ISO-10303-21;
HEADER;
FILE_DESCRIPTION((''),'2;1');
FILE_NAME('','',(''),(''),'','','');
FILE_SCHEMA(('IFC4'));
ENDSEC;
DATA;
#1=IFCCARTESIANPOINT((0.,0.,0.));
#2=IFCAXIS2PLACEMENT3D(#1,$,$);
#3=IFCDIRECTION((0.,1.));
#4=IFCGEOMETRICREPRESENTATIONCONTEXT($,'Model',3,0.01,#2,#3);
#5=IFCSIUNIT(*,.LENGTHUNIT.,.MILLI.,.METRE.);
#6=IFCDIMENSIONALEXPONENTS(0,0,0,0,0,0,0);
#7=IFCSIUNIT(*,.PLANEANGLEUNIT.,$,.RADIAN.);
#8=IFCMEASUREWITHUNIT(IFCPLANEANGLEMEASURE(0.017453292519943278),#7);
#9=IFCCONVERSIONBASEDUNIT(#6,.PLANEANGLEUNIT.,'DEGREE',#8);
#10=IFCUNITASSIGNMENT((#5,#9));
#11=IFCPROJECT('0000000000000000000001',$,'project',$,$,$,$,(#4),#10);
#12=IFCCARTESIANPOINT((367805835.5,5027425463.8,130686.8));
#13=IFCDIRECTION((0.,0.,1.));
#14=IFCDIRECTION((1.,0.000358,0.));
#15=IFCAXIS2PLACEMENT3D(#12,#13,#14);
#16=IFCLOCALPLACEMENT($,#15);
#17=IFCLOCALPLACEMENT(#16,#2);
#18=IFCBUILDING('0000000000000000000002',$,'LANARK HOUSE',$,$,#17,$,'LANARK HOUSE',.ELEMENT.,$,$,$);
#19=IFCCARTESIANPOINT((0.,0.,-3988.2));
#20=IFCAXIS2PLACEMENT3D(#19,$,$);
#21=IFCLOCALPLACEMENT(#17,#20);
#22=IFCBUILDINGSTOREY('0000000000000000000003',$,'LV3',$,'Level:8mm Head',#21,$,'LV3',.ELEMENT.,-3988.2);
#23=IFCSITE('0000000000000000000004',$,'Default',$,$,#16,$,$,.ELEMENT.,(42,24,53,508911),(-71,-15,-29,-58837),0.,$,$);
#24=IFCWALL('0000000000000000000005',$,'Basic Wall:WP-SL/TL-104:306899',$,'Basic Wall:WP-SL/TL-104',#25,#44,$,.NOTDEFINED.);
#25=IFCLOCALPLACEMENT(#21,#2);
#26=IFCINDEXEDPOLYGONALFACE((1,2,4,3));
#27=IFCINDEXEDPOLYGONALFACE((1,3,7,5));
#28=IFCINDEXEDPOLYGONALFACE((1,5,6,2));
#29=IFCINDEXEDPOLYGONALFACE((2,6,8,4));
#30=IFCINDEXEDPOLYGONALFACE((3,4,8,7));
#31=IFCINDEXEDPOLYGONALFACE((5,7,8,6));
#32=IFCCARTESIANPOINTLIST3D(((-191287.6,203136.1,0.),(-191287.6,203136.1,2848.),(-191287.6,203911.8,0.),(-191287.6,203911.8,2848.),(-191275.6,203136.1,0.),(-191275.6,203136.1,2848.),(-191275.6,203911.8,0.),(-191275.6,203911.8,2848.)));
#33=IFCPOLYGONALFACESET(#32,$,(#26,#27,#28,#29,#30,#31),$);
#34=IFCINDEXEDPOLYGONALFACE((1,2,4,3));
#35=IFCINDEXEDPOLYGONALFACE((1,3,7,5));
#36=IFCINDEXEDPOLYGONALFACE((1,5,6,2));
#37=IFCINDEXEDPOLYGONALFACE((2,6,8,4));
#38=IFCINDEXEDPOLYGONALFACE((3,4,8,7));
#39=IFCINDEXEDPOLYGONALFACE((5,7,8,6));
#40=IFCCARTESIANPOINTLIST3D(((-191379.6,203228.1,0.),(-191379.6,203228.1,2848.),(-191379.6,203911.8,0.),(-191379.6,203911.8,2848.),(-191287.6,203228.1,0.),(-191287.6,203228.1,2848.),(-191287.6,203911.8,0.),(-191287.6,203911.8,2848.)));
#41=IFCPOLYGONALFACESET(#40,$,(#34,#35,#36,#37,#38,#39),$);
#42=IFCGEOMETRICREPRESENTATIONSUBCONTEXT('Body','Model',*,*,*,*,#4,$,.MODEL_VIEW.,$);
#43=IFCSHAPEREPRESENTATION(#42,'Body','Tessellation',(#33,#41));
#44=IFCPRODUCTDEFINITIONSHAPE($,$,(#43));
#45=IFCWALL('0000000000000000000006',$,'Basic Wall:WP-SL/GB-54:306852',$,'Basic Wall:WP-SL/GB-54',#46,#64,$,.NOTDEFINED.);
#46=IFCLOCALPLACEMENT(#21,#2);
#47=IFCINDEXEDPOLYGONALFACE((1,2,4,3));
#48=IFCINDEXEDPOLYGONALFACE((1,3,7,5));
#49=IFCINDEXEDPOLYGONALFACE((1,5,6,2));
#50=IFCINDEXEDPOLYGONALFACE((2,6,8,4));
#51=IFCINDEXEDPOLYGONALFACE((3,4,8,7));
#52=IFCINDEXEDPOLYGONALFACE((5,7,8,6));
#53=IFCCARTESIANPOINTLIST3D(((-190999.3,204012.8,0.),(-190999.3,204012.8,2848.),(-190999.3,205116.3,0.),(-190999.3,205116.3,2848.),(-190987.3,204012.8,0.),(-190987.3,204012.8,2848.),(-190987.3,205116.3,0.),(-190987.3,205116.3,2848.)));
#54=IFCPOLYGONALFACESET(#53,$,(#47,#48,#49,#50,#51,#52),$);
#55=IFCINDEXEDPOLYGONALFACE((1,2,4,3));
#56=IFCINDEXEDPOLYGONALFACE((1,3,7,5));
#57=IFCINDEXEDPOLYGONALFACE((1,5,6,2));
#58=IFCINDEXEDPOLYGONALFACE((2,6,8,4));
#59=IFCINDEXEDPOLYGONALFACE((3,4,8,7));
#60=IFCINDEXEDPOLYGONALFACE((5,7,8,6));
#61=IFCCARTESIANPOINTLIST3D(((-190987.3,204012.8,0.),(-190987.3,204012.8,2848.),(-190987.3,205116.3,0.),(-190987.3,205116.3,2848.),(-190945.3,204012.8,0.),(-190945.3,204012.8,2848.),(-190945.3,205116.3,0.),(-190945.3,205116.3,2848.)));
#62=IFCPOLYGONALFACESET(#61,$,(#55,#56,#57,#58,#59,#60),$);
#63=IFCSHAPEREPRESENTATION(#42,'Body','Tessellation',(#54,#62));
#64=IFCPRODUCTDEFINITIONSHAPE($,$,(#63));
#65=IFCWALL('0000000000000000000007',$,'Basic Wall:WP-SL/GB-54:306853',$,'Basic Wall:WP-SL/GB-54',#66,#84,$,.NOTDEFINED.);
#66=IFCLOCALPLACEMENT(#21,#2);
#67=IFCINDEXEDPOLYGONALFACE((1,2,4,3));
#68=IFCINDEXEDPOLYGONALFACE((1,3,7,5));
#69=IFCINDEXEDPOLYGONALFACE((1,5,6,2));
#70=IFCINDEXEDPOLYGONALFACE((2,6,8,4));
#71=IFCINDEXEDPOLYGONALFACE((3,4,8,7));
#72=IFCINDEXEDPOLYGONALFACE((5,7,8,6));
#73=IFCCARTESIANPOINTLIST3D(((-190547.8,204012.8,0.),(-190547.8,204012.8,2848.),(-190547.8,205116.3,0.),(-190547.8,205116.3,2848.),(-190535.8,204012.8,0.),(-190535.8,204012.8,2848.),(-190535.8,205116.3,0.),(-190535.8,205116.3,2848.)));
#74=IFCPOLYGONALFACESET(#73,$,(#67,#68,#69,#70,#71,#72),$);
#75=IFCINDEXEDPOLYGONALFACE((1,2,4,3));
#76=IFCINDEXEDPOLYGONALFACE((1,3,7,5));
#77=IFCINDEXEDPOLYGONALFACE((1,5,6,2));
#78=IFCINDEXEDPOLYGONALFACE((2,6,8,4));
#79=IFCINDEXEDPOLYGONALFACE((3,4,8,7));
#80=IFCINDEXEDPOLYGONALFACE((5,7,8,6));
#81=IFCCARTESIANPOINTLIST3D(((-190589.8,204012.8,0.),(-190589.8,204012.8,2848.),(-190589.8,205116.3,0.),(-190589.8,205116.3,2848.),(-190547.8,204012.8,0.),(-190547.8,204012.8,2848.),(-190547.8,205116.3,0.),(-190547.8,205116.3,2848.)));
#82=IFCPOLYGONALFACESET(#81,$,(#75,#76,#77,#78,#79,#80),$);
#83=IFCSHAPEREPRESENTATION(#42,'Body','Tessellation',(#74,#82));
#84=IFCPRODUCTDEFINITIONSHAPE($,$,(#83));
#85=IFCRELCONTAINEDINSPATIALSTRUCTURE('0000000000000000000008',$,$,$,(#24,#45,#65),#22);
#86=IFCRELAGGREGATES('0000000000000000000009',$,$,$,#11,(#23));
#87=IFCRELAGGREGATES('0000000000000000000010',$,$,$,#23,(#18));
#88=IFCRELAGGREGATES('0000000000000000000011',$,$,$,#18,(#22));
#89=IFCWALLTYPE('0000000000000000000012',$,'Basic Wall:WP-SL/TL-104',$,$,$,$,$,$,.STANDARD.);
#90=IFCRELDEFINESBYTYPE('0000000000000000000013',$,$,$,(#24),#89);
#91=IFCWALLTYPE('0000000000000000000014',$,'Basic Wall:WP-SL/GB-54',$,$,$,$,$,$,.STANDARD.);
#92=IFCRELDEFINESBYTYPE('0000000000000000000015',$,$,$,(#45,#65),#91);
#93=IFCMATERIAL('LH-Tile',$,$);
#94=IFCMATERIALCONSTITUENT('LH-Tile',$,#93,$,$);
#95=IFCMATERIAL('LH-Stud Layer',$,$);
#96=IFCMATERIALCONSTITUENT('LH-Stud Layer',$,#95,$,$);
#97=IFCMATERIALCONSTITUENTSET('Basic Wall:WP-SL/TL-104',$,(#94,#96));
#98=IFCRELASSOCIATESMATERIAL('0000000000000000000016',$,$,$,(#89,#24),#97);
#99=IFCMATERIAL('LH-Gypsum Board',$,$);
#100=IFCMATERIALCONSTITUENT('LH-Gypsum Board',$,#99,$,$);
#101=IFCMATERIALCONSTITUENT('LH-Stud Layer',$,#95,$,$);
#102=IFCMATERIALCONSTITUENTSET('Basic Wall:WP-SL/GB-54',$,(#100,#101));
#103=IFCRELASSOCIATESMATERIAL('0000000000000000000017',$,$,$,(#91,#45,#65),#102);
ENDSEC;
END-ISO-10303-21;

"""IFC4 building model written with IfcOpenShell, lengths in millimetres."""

from ifc_helpers import new_model, entity, si_unit, converted_unit, direction, frame, origin, place, context, subcontext, project, spatial, indexed_curve, outline, extrude, material, constituent, constituent_set, type_object, element, save


model = new_model("IFC4")

# Units and contexts
model_context = context("Model", 3, precision=0.01, world=origin(), true_north=direction((0.0, 1.0)))
body_context = subcontext(model_context, "Body", "Model", "MODEL_VIEW")
ifc_project = project(units=[si_unit("LENGTHUNIT", "METRE", prefix="MILLI"), converted_unit("PLANEANGLEUNIT", "DEGREE", entity("IfcPlaneAngleMeasure", 0.017453292519943278), si_unit("PLANEANGLEUNIT", "RADIAN"), dimensions=[0, 0, 0, 0, 0, 0, 0])], contexts=[model_context])

# Site, building, storey
site_placement = place(None, frame((367805835.5, 5027425463.8, 130686.8), z_axis=(0.0, 0.0, 1.0), x_axis=(1.0, 0.000358, 0.0)))
site = spatial("IfcSite", under=ifc_project, at=site_placement, Name="Default", CompositionType="ELEMENT", RefLatitude=(42, 24, 53, 508911), RefLongitude=(-71, -15, -29, -58837), RefElevation=0.0)
building_placement = place(site_placement, origin())
building = spatial("IfcBuilding", under=site, at=building_placement, Name="LANARK HOUSE", LongName="LANARK HOUSE", CompositionType="ELEMENT")
storey_placement = place(building_placement, frame((0.0, 0.0, -3988.2)))
storey = spatial("IfcBuildingStorey", under=building, at=storey_placement, Name="LV3", ObjectType="Level:8mm Head", LongName="LV3", CompositionType="ELEMENT", Elevation=-3988.2)

# Shared definitions
ifc_material_1 = material(Name="LH-Gypsum Board")
ifc_material_2 = material(Name="LH-Stud Layer")

# Walls
ifc_material_3 = material(Name="LH-Tile")
ifc_constituent_1 = constituent(ifc_material_3, Name="LH-Tile")
ifc_constituent_2 = constituent(ifc_material_2, Name="LH-Stud Layer")
ifc_constituent_set_1 = constituent_set(constituents=[ifc_constituent_1, ifc_constituent_2], Name="Basic Wall:WP-SL/TL-104")
wall_type_1 = type_object("IfcWallType", Name="Basic Wall:WP-SL/TL-104", PredefinedType="STANDARD", material=ifc_constituent_set_1)
wall_1_placement = place(storey_placement, frame((-191327.6, 203911.8, 0.0), z_axis=(0.0, 0.0, 1.0), x_axis=(0.0, -1.0, 0.0)))
element("IfcWall", 1, at=wall_1_placement, inside=storey, type_object=wall_type_1, material=ifc_constituent_set_1, Name="Basic Wall:WP-SL/TL-104:306899", ObjectType="Basic Wall:WP-SL/TL-104", PredefinedType="NOTDEFINED", context=body_context, shape_type="SweptSolid", body=[
    extrude(outline(indexed_curve([(-6.0, -387.8), (6.0, -387.8), (6.0, 387.8), (-6.0, 387.8), (-6.0, -387.8)], self_intersect=False)), frame((387.8, 46.0, 0.0), z_axis=(0.0, 0.0, 1.0), x_axis=(0.0, -1.0, 0.0)), (0.0, 0.0, 1.0), 2848.0),
    extrude(outline(indexed_curve([(-46.0, -341.8), (46.0, -341.8), (46.0, 341.8), (-46.0, 341.8), (-46.0, -341.8)], self_intersect=False)), frame((341.8, -6.0, 0.0), z_axis=(0.0, 0.0, 1.0), x_axis=(0.0, 1.0, 0.0)), (0.0, 0.0, 1.0), 2848.0),
])
ifc_constituent_3 = constituent(ifc_material_1, Name="LH-Gypsum Board")
ifc_constituent_4 = constituent(ifc_material_2, Name="LH-Stud Layer")
ifc_constituent_set_2 = constituent_set(constituents=[ifc_constituent_3, ifc_constituent_4], Name="Basic Wall:WP-SL/GB-54")
wall_type_2 = type_object("IfcWallType", Name="Basic Wall:WP-SL/GB-54", PredefinedType="STANDARD", material=ifc_constituent_set_2)
wall_2_placement = place(storey_placement, frame((-190972.3, 204012.8, 0.0), z_axis=(0.0, 0.0, 1.0), x_axis=(0.0, 1.0, 0.0)))
element("IfcWall", 2, at=wall_2_placement, inside=storey, type_object=wall_type_2, material=ifc_constituent_set_2, Name="Basic Wall:WP-SL/GB-54:306852", ObjectType="Basic Wall:WP-SL/GB-54", PredefinedType="NOTDEFINED", context=body_context, shape_type="SweptSolid", body=[
    extrude(outline(indexed_curve([(-6.0, -551.8), (6.0, -551.8), (6.0, 551.8), (-6.0, 551.8), (-6.0, -551.8)], self_intersect=False)), frame((551.8, 21.0, 0.0), z_axis=(0.0, 0.0, 1.0), x_axis=(0.0, -1.0, 0.0)), (0.0, 0.0, 1.0), 2848.0),
    extrude(outline(indexed_curve([(-21.0, -551.8), (21.0, -551.8), (21.0, 551.8), (-21.0, 551.8), (-21.0, -551.8)], self_intersect=False)), frame((551.8, -6.0, 0.0), z_axis=(0.0, 0.0, 1.0), x_axis=(0.0, 1.0, 0.0)), (0.0, 0.0, 1.0), 2848.0),
])
wall_3_placement = place(storey_placement, frame((-190562.8, 205116.3, 0.0), z_axis=(0.0, 0.0, 1.0), x_axis=(0.0, -1.0, 0.0)))
element("IfcWall", 3, at=wall_3_placement, inside=storey, type_object=wall_type_2, material=ifc_constituent_set_2, Name="Basic Wall:WP-SL/GB-54:306853", ObjectType="Basic Wall:WP-SL/GB-54", PredefinedType="NOTDEFINED", context=body_context, shape_type="SweptSolid", body=[
    extrude(outline(indexed_curve([(-6.0, -551.8), (6.0, -551.8), (6.0, 551.8), (-6.0, 551.8), (-6.0, -551.8)], self_intersect=False)), frame((551.8, 21.0, 0.0), z_axis=(0.0, 0.0, 1.0), x_axis=(0.0, -1.0, 0.0)), (0.0, 0.0, 1.0), 2848.0),
    extrude(outline(indexed_curve([(-21.0, -551.8), (21.0, -551.8), (21.0, 551.8), (-21.0, 551.8), (-21.0, -551.8)], self_intersect=False)), frame((551.8, -6.0, 0.0), z_axis=(0.0, 0.0, 1.0), x_axis=(0.0, 1.0, 0.0)), (0.0, 0.0, 1.0), 2848.0),
])

save(model, "model.ifc")
